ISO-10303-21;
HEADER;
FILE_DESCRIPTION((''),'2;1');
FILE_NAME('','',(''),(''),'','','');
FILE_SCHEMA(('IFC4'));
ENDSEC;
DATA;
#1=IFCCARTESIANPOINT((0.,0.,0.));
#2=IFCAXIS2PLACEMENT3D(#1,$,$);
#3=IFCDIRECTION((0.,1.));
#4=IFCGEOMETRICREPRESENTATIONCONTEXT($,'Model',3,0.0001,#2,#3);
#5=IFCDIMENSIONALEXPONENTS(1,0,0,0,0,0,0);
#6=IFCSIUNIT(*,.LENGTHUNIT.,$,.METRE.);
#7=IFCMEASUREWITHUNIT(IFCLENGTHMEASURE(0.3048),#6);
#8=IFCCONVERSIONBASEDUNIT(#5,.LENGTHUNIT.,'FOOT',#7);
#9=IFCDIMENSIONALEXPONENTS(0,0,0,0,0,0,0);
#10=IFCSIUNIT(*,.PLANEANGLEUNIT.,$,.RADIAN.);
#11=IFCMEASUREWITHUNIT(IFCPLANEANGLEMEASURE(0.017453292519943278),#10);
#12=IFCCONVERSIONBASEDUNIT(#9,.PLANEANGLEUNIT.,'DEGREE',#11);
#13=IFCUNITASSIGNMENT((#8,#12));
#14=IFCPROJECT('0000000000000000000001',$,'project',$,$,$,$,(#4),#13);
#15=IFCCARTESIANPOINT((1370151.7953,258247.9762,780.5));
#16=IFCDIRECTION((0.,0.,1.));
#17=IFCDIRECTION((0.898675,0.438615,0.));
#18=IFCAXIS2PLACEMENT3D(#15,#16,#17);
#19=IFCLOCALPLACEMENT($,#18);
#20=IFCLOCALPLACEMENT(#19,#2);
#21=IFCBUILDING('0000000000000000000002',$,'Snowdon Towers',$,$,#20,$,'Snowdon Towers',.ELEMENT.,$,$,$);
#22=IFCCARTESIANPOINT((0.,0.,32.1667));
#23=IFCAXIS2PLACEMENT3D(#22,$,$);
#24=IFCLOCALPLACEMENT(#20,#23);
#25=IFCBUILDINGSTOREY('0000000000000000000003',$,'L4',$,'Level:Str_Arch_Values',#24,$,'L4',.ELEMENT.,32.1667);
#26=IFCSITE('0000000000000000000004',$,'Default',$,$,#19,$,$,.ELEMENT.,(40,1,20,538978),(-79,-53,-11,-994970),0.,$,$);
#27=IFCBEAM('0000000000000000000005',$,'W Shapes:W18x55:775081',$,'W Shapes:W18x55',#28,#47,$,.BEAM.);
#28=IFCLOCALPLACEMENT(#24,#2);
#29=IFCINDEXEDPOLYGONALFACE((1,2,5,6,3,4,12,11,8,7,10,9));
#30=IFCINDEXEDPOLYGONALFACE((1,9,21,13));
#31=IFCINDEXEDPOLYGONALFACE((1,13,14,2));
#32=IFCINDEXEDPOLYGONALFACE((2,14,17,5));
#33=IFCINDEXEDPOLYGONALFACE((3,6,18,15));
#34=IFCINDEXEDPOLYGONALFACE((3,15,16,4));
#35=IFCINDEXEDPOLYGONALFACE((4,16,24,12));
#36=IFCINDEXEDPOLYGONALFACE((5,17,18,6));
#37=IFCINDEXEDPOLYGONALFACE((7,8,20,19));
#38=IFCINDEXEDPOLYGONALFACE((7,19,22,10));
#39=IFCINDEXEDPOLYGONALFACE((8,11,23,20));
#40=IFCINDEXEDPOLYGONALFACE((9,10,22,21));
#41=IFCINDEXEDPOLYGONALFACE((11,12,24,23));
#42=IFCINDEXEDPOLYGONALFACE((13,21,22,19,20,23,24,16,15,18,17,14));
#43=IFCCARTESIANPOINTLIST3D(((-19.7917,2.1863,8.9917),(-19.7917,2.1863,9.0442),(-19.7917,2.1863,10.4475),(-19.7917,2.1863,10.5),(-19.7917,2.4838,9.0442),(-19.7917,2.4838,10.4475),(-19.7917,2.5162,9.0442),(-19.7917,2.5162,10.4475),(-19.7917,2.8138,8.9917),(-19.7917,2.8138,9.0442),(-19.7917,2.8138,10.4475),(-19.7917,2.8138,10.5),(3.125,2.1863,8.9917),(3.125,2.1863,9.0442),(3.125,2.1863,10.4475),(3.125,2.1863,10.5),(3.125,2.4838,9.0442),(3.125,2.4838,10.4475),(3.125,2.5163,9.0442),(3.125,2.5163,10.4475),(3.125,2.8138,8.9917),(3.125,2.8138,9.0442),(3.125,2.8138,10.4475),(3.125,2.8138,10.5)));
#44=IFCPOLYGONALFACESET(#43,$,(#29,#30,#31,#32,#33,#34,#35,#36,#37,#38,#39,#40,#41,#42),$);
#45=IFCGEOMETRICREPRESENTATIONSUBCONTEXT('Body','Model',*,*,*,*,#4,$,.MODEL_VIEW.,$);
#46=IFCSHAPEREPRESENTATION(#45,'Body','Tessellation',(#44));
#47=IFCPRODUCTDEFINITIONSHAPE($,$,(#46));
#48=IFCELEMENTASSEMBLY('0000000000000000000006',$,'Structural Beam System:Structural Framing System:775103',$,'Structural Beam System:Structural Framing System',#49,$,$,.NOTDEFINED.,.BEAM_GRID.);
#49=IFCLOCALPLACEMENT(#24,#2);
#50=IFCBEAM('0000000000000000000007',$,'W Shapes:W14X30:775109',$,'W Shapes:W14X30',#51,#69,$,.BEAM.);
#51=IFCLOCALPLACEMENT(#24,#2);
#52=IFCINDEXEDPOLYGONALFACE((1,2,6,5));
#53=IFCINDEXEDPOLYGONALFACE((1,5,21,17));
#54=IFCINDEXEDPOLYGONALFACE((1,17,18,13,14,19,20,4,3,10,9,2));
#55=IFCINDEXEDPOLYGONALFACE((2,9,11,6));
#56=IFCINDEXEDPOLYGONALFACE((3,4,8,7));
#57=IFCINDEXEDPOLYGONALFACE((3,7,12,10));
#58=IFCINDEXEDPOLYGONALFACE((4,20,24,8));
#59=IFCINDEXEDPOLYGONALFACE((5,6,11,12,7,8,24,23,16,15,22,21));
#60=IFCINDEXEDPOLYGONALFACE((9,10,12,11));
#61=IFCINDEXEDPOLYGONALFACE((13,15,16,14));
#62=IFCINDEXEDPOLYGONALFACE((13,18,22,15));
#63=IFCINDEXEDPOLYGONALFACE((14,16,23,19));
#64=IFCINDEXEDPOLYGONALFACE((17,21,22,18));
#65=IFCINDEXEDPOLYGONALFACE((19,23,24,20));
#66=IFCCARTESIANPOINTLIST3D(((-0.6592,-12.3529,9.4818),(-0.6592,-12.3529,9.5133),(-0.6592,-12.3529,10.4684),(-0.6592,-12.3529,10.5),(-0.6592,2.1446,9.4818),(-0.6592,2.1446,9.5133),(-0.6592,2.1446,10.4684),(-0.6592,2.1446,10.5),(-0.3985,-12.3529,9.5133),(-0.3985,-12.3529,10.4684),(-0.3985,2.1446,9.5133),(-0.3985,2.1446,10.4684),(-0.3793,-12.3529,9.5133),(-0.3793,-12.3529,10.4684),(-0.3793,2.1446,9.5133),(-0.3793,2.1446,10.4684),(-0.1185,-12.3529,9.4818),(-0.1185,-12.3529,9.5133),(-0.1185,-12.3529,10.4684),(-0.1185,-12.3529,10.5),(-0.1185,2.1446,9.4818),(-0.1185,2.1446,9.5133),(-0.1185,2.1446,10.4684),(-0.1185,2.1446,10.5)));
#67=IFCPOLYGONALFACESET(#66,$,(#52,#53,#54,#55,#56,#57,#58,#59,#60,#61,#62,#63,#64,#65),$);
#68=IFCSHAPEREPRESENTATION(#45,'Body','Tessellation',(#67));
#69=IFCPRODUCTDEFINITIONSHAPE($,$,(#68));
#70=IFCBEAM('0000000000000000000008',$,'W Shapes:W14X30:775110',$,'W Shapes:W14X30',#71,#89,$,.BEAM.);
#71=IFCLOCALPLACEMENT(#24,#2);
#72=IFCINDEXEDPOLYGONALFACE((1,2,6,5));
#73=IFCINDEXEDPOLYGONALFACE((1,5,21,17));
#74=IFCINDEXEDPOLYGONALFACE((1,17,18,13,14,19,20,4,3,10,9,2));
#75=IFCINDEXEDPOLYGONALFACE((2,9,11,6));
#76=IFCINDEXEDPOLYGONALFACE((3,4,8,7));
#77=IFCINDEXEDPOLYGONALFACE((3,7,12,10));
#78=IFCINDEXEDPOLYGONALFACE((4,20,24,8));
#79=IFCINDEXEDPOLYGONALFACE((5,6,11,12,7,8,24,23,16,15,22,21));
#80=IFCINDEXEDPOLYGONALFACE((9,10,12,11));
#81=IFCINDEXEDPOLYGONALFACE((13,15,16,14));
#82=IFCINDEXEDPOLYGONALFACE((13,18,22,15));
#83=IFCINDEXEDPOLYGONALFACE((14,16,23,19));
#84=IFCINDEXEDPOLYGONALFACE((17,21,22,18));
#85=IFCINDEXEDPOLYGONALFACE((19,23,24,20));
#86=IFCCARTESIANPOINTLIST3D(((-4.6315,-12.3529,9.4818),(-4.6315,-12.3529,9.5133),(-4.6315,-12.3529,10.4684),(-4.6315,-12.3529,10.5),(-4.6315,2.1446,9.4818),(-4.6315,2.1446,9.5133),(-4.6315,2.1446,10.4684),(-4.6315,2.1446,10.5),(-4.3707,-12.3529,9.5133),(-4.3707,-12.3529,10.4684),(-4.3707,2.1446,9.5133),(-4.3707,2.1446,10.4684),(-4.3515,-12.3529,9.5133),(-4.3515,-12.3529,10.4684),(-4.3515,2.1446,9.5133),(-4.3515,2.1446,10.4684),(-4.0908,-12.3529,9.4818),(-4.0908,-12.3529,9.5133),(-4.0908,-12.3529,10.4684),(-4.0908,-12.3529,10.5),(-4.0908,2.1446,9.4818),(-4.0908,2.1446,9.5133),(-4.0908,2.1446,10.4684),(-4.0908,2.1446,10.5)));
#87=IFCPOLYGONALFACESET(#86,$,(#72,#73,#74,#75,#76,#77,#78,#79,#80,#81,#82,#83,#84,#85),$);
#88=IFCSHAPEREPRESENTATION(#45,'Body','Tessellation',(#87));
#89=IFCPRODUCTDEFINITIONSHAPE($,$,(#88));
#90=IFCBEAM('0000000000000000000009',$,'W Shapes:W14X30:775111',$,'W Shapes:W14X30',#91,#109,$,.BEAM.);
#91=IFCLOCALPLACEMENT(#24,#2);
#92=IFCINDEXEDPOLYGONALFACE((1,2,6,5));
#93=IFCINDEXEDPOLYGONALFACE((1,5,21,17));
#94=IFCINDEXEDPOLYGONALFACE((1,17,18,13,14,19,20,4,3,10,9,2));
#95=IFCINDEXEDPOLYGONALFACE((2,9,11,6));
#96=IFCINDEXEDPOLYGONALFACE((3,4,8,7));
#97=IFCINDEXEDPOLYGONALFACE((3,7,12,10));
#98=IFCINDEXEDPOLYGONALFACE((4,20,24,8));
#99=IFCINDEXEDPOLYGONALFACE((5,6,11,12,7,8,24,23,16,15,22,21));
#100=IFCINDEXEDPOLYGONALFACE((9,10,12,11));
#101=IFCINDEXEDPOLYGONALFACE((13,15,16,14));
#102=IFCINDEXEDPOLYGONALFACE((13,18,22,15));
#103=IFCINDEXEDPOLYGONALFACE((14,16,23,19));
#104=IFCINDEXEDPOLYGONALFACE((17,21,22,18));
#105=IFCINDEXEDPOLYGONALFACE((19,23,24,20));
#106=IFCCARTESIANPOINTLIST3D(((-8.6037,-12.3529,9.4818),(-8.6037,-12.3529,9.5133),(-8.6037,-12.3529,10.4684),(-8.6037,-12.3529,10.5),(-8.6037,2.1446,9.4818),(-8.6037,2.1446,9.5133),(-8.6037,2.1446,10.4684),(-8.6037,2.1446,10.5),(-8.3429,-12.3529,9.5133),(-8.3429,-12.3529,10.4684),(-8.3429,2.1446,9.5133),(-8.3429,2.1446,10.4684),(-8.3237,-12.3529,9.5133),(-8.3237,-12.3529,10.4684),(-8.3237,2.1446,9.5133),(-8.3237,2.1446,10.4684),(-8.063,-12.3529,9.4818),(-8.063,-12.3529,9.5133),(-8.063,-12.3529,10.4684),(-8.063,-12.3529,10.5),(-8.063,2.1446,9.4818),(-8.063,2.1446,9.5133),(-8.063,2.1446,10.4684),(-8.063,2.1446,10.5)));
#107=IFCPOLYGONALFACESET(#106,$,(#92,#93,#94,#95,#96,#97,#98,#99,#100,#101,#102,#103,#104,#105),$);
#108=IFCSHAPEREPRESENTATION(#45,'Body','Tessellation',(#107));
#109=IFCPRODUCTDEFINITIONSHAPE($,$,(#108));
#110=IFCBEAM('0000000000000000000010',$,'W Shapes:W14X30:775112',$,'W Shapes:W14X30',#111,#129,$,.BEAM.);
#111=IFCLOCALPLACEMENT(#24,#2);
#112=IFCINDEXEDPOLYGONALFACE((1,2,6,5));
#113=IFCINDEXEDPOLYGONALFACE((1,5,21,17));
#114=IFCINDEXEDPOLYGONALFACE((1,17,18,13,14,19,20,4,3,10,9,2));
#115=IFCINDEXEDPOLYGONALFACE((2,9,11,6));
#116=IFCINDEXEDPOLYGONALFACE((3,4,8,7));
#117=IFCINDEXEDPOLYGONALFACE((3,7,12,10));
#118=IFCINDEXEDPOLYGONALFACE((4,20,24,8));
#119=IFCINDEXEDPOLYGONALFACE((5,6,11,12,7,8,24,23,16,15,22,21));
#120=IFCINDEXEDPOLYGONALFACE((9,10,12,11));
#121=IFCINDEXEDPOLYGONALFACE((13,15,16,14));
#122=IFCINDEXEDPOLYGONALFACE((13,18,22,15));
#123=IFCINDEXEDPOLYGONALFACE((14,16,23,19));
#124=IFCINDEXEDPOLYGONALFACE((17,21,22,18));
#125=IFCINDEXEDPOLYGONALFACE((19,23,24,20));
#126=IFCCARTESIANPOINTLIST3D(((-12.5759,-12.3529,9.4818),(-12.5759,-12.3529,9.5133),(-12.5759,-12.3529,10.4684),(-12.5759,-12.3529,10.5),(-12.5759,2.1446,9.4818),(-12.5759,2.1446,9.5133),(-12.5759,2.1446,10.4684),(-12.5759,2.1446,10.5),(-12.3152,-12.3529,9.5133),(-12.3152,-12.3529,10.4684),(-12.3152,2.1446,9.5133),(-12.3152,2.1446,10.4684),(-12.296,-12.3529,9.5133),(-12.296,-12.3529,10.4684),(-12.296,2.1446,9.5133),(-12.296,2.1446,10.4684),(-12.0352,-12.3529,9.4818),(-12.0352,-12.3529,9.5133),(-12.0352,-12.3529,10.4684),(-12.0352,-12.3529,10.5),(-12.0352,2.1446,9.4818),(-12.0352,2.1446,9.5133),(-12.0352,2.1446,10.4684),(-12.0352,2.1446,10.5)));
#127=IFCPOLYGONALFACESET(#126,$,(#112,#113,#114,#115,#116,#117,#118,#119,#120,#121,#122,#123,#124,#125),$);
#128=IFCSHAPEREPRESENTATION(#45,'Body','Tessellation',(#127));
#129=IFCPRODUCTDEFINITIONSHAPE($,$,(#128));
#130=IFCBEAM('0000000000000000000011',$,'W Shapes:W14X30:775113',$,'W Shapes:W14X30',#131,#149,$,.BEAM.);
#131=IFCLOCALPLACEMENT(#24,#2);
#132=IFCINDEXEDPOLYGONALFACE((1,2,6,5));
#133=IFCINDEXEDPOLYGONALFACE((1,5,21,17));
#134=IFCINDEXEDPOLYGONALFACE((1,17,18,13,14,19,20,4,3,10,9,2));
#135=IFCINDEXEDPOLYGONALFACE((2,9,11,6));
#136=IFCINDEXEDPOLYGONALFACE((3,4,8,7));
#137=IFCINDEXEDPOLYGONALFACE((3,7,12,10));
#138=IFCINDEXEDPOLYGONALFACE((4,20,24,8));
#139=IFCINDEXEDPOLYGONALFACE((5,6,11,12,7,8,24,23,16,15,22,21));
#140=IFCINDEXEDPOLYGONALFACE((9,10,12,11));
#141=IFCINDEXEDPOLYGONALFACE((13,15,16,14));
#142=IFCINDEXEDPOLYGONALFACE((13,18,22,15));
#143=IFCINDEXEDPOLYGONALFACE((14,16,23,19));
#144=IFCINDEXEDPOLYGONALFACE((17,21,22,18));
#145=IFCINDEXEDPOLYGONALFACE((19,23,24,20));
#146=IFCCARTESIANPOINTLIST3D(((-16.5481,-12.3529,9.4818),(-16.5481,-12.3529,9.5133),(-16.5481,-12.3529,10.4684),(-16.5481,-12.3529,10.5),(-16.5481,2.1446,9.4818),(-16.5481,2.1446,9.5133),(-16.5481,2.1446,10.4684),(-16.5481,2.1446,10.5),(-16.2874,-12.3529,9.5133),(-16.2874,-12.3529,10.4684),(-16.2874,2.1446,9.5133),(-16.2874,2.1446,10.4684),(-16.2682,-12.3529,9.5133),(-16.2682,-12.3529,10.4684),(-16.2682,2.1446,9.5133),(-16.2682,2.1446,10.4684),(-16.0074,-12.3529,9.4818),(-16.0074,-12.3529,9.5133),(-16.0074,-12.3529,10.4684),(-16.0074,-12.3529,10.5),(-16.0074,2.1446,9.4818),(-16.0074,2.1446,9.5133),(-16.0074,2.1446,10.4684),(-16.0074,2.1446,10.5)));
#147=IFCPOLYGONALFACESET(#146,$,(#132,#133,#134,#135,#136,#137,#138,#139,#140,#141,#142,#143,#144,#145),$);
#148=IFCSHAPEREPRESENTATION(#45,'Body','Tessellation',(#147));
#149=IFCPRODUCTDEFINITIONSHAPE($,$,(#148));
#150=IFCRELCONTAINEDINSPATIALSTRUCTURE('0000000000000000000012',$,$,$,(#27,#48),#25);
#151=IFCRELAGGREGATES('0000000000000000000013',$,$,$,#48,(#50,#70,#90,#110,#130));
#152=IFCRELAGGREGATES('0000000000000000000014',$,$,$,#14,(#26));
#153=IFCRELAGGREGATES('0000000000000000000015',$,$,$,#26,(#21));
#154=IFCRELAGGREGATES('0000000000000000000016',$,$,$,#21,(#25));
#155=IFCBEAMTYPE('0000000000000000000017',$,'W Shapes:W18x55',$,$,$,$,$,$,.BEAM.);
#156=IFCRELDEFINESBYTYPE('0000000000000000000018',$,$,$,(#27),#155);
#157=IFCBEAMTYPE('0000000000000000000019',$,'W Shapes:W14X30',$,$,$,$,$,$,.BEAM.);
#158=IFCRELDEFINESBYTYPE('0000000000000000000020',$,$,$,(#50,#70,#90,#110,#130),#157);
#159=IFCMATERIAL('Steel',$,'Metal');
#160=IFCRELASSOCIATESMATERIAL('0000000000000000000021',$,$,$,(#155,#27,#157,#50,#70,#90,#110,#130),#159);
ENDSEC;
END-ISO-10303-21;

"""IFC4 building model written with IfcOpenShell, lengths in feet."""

from ifc_helpers import new_model, entity, si_unit, converted_unit, direction, frame, origin, place, context, subcontext, project, spatial, indexed_curve, outline, extrude, source, transform, mapped, material, type_object, type_shapes, element, aggregate, save


model = new_model("IFC4")

# Units and contexts
model_context = context("Model", 3, precision=0.0001, world=origin(), true_north=direction((0.0, 1.0)))
body_context = subcontext(model_context, "Body", "Model", "MODEL_VIEW")
ifc_project = project(units=[converted_unit("LENGTHUNIT", "FOOT", entity("IfcLengthMeasure", 0.3048), si_unit("LENGTHUNIT", "METRE"), dimensions=[1, 0, 0, 0, 0, 0, 0]), converted_unit("PLANEANGLEUNIT", "DEGREE", entity("IfcPlaneAngleMeasure", 0.017453292519943278), si_unit("PLANEANGLEUNIT", "RADIAN"), dimensions=[0, 0, 0, 0, 0, 0, 0])], contexts=[model_context])

# Site, building, storey
site_placement = place(None, frame((1370151.7953, 258247.9762, 780.5), z_axis=(0.0, 0.0, 1.0), x_axis=(0.898675, 0.438615, 0.0)))
site = spatial("IfcSite", under=ifc_project, at=site_placement, Name="Default", CompositionType="ELEMENT", RefLatitude=(40, 1, 20, 538978), RefLongitude=(-79, -53, -11, -994970), RefElevation=0.0)
building_placement = place(site_placement, origin())
building = spatial("IfcBuilding", under=site, at=building_placement, Name="Snowdon Towers", LongName="Snowdon Towers", CompositionType="ELEMENT")
storey_placement = place(building_placement, frame((0.0, 0.0, 32.1667)))
storey = spatial("IfcBuildingStorey", under=building, at=storey_placement, Name="L4", ObjectType="Level:Str_Arch_Values", LongName="L4", CompositionType="ELEMENT", Elevation=32.1667)

# Shared definitions
ifc_material_1 = material(Name="Steel", Category="Metal")

# Beam
beam_type_1 = type_object("IfcBeamType", Name="W Shapes:W18x55", PredefinedType="BEAM", material=ifc_material_1)
shared_shape_1 = source(origin(), body_context, "Body", "SweptSolid", [
    extrude(outline(indexed_curve([(-0.3138, -0.7017), (-0.3138, -0.7542), (0.3138, -0.7542), (0.3138, -0.7017), (0.0162, -0.7017), (0.0162, 0.7017), (0.3138, 0.7017), (0.3138, 0.7542), (-0.3137, 0.7542), (-0.3137, 0.7017), (-0.0163, 0.7017), (-0.0163, -0.7017), (-0.3138, -0.7017)], self_intersect=False)), frame((-11.4583, 0.0, 0.0), z_axis=(-1.0, 0.0, 0.0), x_axis=(0.0, -1.0, 0.0)), (0.0, 0.0, -1.0), 22.9167),
])
type_shapes(beam_type_1, [shared_shape_1])
beam_1_placement = place(storey_placement, frame((-8.3333, 2.5, 9.7458)))
element("IfcBeam", 1, at=beam_1_placement, inside=storey, type_object=beam_type_1, material=ifc_material_1, Name="W Shapes:W18x55:775081", ObjectType="W Shapes:W18x55", PredefinedType="BEAM", context=body_context, shape_type="MappedRepresentation", body=[
    mapped(shared_shape_1, transform((0.0, 0.0, 0.0), scale=1.0)),
])

# Element assembly, beams
assembly_1_placement = place(storey_placement, origin())
assembly_1 = element("IfcElementAssembly", 2, at=assembly_1_placement, inside=storey, Name="Structural Beam System:Structural Framing System:775103", ObjectType="Structural Beam System:Structural Framing System", AssemblyPlace="NOTDEFINED", PredefinedType="BEAM_GRID")
beam_type_2 = type_object("IfcBeamType", Name="W Shapes:W14X30", PredefinedType="BEAM", material=ifc_material_1)
shared_shape_2 = source(origin(), body_context, "Body", "SweptSolid", [
    extrude(outline(indexed_curve([(-0.2703, -0.4775), (-0.2703, -0.5091), (0.2703, -0.5091), (0.2703, -0.4775), (0.0096, -0.4775), (0.0096, 0.4775), (0.2703, 0.4775), (0.2703, 0.5091), (-0.2703, 0.5091), (-0.2703, 0.4775), (-0.0096, 0.4775), (-0.0096, -0.4775), (-0.2703, -0.4775)], self_intersect=False)), frame((-7.2487, 0.0, 0.0), z_axis=(-1.0, 0.0, 0.0), x_axis=(0.0, -1.0, 0.0)), (0.0, 0.0, -1.0), 14.4975),
])
type_shapes(beam_type_2, [shared_shape_2])
beam_2_placement = place(assembly_1_placement, frame((-0.3889, -5.1042, 9.9909), z_axis=(0.0, 0.0, 1.0), x_axis=(0.0, -1.0, 0.0)))
beam_2 = element("IfcBeam", 3, at=beam_2_placement, type_object=beam_type_2, material=ifc_material_1, Name="W Shapes:W14X30:775109", ObjectType="W Shapes:W14X30", PredefinedType="BEAM", context=body_context, shape_type="MappedRepresentation", body=[
    mapped(shared_shape_2, transform((0.0, 0.0, 0.0), scale=1.0)),
])
beam_3_placement = place(assembly_1_placement, frame((-4.3611, -5.1042, 9.9909), z_axis=(0.0, 0.0, 1.0), x_axis=(0.0, -1.0, 0.0)))
beam_3 = element("IfcBeam", 4, at=beam_3_placement, type_object=beam_type_2, material=ifc_material_1, Name="W Shapes:W14X30:775110", ObjectType="W Shapes:W14X30", PredefinedType="BEAM", context=body_context, shape_type="MappedRepresentation", body=[
    mapped(shared_shape_2, transform((0.0, 0.0, 0.0), scale=1.0)),
])
beam_4_placement = place(assembly_1_placement, frame((-8.3333, -5.1042, 9.9909), z_axis=(0.0, 0.0, 1.0), x_axis=(0.0, -1.0, 0.0)))
beam_4 = element("IfcBeam", 5, at=beam_4_placement, type_object=beam_type_2, material=ifc_material_1, Name="W Shapes:W14X30:775111", ObjectType="W Shapes:W14X30", PredefinedType="BEAM", context=body_context, shape_type="MappedRepresentation", body=[
    mapped(shared_shape_2, transform((0.0, 0.0, 0.0), scale=1.0)),
])
beam_5_placement = place(assembly_1_placement, frame((-12.3056, -5.1042, 9.9909), z_axis=(0.0, 0.0, 1.0), x_axis=(0.0, -1.0, 0.0)))
beam_5 = element("IfcBeam", 6, at=beam_5_placement, type_object=beam_type_2, material=ifc_material_1, Name="W Shapes:W14X30:775112", ObjectType="W Shapes:W14X30", PredefinedType="BEAM", context=body_context, shape_type="MappedRepresentation", body=[
    mapped(shared_shape_2, transform((0.0, 0.0, 0.0), scale=1.0)),
])
beam_6_placement = place(assembly_1_placement, frame((-16.2778, -5.1042, 9.9909), z_axis=(0.0, 0.0, 1.0), x_axis=(0.0, -1.0, 0.0)))
beam_6 = element("IfcBeam", 7, at=beam_6_placement, type_object=beam_type_2, material=ifc_material_1, Name="W Shapes:W14X30:775113", ObjectType="W Shapes:W14X30", PredefinedType="BEAM", context=body_context, shape_type="MappedRepresentation", body=[
    mapped(shared_shape_2, transform((0.0, 0.0, 0.0), scale=1.0)),
])
aggregate(assembly_1, [beam_2, beam_3, beam_4, beam_5, beam_6])

save(model, "model.ifc")
